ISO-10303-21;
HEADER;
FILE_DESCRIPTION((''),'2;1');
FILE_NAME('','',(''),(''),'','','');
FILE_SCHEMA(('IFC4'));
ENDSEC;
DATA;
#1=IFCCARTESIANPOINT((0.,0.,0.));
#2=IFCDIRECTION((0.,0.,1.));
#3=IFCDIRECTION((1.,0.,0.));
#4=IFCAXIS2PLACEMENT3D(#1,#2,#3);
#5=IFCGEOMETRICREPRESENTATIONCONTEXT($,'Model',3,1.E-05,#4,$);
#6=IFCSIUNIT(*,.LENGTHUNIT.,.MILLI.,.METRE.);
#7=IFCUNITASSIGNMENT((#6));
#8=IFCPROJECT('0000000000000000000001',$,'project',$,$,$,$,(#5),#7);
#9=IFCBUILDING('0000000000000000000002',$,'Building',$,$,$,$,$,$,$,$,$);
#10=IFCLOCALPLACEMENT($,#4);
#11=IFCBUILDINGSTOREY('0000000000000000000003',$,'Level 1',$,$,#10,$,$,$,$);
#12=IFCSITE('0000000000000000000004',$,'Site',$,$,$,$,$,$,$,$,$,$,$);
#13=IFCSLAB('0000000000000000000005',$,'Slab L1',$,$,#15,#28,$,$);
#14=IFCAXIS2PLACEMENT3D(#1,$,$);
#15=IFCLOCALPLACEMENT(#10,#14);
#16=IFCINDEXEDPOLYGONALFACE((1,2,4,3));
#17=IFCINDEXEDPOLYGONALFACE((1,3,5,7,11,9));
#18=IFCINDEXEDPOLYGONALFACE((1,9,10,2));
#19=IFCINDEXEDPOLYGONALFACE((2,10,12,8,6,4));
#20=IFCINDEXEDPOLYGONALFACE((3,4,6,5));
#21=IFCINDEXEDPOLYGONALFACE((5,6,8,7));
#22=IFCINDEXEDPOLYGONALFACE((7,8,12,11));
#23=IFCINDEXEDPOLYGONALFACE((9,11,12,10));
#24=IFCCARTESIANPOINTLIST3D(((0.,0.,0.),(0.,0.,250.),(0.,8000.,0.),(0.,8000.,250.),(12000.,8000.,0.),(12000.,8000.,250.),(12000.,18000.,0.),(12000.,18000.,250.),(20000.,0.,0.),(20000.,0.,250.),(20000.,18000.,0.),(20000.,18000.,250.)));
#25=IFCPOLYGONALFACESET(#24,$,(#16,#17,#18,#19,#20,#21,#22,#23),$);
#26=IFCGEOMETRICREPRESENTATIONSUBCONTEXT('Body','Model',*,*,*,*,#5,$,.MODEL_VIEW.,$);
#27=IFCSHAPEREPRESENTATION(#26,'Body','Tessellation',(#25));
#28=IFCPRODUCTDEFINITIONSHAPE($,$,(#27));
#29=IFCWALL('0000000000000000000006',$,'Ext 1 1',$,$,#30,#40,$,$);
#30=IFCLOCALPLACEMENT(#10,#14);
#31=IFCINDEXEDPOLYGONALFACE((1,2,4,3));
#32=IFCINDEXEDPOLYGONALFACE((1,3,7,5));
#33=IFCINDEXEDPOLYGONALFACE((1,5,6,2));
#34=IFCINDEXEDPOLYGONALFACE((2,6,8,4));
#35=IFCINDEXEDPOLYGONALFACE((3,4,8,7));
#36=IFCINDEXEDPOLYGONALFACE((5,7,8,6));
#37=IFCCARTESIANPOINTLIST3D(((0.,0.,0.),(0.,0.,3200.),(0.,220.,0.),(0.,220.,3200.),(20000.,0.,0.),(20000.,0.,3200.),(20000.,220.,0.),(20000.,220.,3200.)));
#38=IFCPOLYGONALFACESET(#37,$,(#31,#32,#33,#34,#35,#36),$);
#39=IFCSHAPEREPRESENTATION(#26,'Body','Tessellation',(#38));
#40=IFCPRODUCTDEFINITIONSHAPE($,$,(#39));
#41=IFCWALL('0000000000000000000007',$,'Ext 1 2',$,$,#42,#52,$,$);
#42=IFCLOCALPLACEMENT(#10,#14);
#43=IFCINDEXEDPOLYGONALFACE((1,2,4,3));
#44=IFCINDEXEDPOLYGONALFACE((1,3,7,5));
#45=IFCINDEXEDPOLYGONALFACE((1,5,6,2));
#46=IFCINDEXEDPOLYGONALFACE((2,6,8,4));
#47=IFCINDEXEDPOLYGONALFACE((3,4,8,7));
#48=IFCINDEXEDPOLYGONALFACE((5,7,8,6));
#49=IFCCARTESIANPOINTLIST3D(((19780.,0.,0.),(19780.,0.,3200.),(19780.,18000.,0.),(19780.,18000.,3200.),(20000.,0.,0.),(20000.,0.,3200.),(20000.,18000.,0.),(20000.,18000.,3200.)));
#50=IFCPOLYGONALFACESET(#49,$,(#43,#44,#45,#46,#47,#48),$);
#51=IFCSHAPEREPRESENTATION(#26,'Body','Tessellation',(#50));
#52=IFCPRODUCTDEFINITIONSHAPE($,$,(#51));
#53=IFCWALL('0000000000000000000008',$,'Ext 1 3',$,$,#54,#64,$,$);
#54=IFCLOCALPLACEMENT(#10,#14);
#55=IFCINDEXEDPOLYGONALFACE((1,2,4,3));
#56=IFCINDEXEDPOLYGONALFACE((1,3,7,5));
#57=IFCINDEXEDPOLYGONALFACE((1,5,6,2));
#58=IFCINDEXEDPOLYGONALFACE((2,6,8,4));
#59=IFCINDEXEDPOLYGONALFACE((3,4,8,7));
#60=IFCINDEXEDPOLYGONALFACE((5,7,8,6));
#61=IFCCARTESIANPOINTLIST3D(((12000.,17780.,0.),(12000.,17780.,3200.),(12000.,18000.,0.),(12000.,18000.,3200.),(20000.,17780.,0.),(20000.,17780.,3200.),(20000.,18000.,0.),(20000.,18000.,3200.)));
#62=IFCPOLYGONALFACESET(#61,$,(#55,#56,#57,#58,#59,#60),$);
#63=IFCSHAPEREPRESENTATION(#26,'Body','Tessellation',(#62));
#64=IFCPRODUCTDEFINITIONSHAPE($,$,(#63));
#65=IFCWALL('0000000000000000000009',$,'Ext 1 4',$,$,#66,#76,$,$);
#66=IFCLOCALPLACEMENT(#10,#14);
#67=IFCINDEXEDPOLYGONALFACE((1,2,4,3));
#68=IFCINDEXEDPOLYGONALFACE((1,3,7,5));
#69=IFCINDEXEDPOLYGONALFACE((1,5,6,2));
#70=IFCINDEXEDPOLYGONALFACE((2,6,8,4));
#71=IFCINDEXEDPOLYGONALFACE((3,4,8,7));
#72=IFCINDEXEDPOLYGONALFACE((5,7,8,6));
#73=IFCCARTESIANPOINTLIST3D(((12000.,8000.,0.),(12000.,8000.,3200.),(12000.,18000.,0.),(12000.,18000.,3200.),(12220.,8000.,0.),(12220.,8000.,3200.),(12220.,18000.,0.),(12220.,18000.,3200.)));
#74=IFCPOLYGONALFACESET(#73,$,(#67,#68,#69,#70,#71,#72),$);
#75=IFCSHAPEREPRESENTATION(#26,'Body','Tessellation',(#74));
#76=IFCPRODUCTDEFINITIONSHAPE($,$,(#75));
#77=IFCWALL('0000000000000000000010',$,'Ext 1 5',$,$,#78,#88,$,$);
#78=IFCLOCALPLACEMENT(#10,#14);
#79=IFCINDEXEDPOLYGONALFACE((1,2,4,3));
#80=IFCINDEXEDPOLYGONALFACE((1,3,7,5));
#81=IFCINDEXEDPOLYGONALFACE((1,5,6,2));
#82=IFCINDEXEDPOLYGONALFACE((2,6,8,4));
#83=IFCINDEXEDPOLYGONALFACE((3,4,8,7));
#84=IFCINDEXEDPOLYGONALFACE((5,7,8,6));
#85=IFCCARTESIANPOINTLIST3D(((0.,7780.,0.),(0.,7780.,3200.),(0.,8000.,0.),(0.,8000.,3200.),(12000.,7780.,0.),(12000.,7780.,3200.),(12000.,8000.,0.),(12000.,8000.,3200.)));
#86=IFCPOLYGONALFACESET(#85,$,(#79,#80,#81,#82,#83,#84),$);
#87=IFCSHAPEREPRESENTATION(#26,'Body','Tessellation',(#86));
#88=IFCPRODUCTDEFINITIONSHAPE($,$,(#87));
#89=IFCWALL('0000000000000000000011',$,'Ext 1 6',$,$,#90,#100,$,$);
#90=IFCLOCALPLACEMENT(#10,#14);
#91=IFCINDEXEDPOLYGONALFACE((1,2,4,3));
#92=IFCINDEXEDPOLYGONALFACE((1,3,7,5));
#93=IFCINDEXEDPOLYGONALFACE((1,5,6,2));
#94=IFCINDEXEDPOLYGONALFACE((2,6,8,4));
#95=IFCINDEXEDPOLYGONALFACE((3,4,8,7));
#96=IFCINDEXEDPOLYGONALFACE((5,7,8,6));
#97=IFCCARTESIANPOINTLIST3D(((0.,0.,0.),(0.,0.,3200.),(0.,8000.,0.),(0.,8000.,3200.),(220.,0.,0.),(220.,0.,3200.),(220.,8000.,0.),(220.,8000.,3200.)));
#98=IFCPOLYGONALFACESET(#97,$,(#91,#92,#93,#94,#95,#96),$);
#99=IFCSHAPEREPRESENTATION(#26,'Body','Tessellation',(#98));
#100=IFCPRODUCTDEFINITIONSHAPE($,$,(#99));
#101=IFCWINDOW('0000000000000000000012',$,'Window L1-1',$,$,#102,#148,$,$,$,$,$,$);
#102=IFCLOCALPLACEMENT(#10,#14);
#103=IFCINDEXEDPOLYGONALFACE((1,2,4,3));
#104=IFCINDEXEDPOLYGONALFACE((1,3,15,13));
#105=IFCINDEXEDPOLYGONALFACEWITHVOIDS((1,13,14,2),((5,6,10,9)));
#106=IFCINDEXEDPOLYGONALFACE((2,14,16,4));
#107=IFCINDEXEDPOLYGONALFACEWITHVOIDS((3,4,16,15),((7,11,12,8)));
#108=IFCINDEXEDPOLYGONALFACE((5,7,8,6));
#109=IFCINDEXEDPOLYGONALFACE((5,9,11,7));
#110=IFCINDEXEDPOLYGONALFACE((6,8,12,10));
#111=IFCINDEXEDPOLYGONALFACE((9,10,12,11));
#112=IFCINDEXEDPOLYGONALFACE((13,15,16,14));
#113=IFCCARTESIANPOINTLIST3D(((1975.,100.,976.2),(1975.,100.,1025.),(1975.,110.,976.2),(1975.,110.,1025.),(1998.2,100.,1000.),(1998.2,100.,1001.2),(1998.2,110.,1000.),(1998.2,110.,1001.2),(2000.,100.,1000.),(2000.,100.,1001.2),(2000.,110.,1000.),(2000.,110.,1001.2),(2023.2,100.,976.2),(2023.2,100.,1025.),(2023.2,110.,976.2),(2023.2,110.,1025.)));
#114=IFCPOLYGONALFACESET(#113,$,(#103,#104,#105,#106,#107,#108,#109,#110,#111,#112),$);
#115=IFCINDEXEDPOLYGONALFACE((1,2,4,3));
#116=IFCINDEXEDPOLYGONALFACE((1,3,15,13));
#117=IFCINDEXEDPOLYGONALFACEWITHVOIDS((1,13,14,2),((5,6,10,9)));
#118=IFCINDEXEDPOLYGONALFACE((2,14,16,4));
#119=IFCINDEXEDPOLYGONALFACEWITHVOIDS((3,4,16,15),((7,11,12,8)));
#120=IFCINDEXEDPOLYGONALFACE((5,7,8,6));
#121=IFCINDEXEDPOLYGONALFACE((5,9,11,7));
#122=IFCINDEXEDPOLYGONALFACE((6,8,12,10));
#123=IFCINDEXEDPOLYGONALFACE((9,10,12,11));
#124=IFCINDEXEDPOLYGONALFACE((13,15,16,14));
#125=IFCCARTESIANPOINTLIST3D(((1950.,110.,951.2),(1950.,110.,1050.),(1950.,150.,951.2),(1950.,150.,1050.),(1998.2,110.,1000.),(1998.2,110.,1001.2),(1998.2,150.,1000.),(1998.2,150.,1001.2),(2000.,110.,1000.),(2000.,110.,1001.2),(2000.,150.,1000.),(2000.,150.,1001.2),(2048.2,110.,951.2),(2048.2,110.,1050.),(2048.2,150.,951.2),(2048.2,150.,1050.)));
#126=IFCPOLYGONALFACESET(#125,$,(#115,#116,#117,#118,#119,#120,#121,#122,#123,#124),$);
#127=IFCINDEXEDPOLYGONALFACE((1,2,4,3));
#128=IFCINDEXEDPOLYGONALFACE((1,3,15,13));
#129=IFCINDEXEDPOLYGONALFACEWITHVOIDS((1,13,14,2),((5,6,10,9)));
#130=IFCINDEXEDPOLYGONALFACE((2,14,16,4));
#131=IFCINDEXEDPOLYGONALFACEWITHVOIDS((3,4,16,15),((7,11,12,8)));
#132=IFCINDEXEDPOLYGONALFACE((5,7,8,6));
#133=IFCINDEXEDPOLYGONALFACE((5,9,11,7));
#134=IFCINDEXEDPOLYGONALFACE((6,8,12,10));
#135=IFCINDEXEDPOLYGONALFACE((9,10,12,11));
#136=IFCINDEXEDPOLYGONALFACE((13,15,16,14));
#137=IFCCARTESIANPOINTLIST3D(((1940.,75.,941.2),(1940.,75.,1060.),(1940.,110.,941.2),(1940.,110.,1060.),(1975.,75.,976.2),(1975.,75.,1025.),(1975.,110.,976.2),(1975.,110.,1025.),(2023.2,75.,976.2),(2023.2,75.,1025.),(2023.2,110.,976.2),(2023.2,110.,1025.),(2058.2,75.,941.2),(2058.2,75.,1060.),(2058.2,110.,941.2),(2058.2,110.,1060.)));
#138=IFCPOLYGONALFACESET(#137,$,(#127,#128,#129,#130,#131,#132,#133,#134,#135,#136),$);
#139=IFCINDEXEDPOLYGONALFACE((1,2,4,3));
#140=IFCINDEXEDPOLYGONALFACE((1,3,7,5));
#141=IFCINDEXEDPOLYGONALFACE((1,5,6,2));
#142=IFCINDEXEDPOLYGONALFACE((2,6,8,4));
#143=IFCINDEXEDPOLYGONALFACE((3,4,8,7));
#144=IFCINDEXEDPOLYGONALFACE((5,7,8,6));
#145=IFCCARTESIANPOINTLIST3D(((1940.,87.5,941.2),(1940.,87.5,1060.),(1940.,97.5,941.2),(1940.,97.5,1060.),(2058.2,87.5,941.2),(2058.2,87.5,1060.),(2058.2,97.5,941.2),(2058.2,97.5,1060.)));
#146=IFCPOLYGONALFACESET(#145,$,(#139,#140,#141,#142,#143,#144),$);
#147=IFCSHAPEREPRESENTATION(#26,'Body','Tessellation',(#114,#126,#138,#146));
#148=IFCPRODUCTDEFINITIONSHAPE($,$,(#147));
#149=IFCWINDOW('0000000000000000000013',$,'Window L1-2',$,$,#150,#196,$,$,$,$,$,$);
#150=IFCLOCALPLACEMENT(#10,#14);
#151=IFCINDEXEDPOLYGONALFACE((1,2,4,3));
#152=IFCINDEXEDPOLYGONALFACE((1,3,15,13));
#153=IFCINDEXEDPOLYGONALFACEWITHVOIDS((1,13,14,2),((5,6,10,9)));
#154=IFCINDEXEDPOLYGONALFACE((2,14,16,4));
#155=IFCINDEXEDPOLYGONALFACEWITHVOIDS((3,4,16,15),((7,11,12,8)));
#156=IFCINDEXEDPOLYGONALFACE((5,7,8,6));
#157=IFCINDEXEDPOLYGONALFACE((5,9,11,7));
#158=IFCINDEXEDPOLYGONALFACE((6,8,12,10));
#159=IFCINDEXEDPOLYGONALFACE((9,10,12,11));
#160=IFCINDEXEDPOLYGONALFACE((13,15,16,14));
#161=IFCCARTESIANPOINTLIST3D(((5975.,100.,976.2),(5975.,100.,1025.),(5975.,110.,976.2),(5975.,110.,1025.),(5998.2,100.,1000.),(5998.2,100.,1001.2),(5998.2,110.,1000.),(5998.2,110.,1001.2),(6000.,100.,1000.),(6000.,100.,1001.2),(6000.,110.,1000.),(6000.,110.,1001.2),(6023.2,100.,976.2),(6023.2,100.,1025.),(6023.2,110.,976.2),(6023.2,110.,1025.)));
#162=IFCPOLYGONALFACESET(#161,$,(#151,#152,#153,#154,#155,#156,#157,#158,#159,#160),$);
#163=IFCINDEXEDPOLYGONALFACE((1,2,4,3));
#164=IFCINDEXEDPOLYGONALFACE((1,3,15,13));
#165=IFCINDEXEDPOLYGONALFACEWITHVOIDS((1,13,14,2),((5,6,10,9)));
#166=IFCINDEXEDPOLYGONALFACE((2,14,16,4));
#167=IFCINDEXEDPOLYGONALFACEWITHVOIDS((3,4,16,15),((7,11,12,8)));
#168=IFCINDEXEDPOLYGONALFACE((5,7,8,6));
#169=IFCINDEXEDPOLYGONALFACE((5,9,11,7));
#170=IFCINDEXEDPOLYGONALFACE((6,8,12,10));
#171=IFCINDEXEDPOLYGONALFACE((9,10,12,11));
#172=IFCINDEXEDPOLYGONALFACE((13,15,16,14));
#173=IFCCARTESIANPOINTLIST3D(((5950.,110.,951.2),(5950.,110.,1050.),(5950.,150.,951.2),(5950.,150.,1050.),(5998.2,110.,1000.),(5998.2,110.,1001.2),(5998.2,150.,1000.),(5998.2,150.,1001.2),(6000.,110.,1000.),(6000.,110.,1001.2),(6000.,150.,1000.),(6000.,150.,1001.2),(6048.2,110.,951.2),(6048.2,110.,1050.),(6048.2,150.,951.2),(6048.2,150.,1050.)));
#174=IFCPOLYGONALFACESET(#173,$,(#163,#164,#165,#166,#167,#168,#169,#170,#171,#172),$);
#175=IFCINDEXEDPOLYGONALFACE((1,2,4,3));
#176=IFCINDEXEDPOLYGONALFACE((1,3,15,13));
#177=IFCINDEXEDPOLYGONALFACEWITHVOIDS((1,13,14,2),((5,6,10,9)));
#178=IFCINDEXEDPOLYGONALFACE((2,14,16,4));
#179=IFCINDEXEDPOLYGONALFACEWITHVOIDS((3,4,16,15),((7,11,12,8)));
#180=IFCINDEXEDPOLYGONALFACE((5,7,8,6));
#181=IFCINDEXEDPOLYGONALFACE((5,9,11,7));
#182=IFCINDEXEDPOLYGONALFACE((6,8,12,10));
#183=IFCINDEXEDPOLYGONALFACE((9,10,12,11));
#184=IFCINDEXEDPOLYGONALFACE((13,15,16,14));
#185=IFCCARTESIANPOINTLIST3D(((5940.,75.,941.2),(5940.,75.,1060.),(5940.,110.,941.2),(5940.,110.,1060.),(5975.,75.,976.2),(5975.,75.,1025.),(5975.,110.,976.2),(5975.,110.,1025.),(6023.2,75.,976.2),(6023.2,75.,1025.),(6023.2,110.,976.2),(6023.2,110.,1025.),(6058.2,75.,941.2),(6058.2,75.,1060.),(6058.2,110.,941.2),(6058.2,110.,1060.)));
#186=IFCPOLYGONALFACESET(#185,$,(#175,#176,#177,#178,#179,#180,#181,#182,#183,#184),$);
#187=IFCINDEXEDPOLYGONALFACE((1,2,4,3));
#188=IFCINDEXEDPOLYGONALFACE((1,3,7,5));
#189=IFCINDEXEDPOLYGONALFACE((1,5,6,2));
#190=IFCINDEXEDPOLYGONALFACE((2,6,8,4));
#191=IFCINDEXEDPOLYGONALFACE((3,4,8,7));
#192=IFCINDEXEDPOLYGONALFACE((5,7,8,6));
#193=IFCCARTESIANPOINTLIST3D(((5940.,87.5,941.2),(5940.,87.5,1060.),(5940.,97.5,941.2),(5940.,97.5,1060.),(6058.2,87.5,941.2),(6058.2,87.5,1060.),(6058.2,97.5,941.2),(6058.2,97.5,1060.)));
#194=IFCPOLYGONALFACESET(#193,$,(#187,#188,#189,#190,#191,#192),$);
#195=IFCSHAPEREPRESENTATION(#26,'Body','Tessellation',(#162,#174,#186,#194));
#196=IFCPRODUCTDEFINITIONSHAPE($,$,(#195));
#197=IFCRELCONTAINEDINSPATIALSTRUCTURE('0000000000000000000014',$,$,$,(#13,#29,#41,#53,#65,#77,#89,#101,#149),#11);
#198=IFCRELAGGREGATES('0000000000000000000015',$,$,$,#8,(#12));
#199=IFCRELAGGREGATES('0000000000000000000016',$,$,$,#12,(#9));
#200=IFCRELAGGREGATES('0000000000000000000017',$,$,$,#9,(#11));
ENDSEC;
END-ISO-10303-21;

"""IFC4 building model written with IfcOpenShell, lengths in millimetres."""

from ifc_helpers import new_model, si_unit, frame, origin_with_axes, place, context, subcontext, project, spatial, line, indexed_curve, outline, extrude, element, save


model = new_model("IFC4")

# Units and contexts
model_context = context("Model", 3, precision=1e-05, world=origin_with_axes())
body_context = subcontext(model_context, "Body", "Model", "MODEL_VIEW")
ifc_project = project(units=[si_unit("LENGTHUNIT", "METRE", prefix="MILLI")], contexts=[model_context])

# Site, building, storey
site = spatial("IfcSite", under=ifc_project, Name="Site")
building = spatial("IfcBuilding", under=site, Name="Building")
storey_placement = place(None, origin_with_axes())
storey = spatial("IfcBuildingStorey", under=building, at=storey_placement, Name="Level 1")

# Slab
slab_placement = place(storey_placement, origin_with_axes())
element("IfcSlab", 1, at=slab_placement, inside=storey, Name="Slab L1", context=body_context, shape_type="SweptSolid", body=[
    extrude(outline(indexed_curve([(0.0, 0.0), (20000.0, 0.0), (20000.0, 18000.0), (12000.0, 18000.0), (12000.0, 8000.0), (0.0, 8000.0), (0.0, 0.0)])), None, (0.0, 0.0, 1.0), 250.0),
])

# Walls
wall_1_placement = place(storey_placement, origin_with_axes())
element("IfcWall", 2, at=wall_1_placement, inside=storey, Name="Ext 1 1", context=body_context, shape_type="SweptSolid", body=[
    extrude(outline(indexed_curve([(0.0, 0.0), (0.0, 220.0), (20000.0, 220.0), (20000.0, 0.0), (0.0, 0.0)], self_intersect=False)), origin_with_axes(), (0.0, 0.0, 1.0), 3200.0),
])
wall_2_placement = place(storey_placement, frame((20000.0, 0.0, 0.0), z_axis=(0.0, 0.0, 1.0), x_axis=(0.0, 1.0, 0.0)))
element("IfcWall", 3, at=wall_2_placement, inside=storey, Name="Ext 1 2", context=body_context, shape_type="SweptSolid", body=[
    extrude(outline(indexed_curve([(0.0, 0.0), (0.0, 220.0), (18000.0, 220.0), (18000.0, 0.0), (0.0, 0.0)], self_intersect=False)), origin_with_axes(), (0.0, 0.0, 1.0), 3200.0),
])
wall_3_placement = place(storey_placement, frame((20000.0, 18000.0, 0.0), z_axis=(0.0, 0.0, 1.0), x_axis=(-1.0, 0.0, 0.0)))
element("IfcWall", 4, at=wall_3_placement, inside=storey, Name="Ext 1 3", context=body_context, shape_type="SweptSolid", body=[
    extrude(outline(indexed_curve([(0.0, 0.0), (0.0, 220.0), (8000.0, 220.0), (8000.0, 0.0), (0.0, 0.0)], self_intersect=False)), origin_with_axes(), (0.0, 0.0, 1.0), 3200.0),
])
wall_4_placement = place(storey_placement, frame((12000.0, 18000.0, 0.0), z_axis=(0.0, 0.0, 1.0), x_axis=(0.0, -1.0, 0.0)))
element("IfcWall", 5, at=wall_4_placement, inside=storey, Name="Ext 1 4", context=body_context, shape_type="SweptSolid", body=[
    extrude(outline(indexed_curve([(0.0, 0.0), (0.0, 220.0), (10000.0, 220.0), (10000.0, 0.0), (0.0, 0.0)], self_intersect=False)), origin_with_axes(), (0.0, 0.0, 1.0), 3200.0),
])
wall_5_placement = place(storey_placement, frame((12000.0, 8000.0, 0.0), z_axis=(0.0, 0.0, 1.0), x_axis=(-1.0, 0.0, 0.0)))
element("IfcWall", 6, at=wall_5_placement, inside=storey, Name="Ext 1 5", context=body_context, shape_type="SweptSolid", body=[
    extrude(outline(indexed_curve([(0.0, 0.0), (0.0, 220.0), (12000.0, 220.0), (12000.0, 0.0), (0.0, 0.0)], self_intersect=False)), origin_with_axes(), (0.0, 0.0, 1.0), 3200.0),
])
wall_6_placement = place(storey_placement, frame((0.0, 8000.0, 0.0), z_axis=(0.0, 0.0, 1.0), x_axis=(0.0, -1.0, 0.0)))
element("IfcWall", 7, at=wall_6_placement, inside=storey, Name="Ext 1 6", context=body_context, shape_type="SweptSolid", body=[
    extrude(outline(indexed_curve([(0.0, 0.0), (0.0, 220.0), (8000.0, 220.0), (8000.0, 0.0), (0.0, 0.0)], self_intersect=False)), origin_with_axes(), (0.0, 0.0, 1.0), 3200.0),
])

# Windows
for number, where, z_axis, x_axis, name in (
    (8, (2000.0, 200.0, 1000.0), (0.0, 0.0, 1.0), (-1.0, 0.0, 0.0), "Window L1-1"),
    (9, (6000.0, 200.0, 1000.0), (0.0, 0.0, 1.0), (-1.0, 0.0, 0.0), "Window L1-2"),
):
    element("IfcWindow", number, at=place(storey_placement, frame(where, z_axis=z_axis, x_axis=x_axis)), inside=storey, Name=name, context=body_context, shape_type="SweptSolid", body=[
        extrude(outline(indexed_curve([(0.0, 0.0), (1.8, 0.0), (1.8, 1.2), (0.0, 1.2)], segments=[line(1, 2, 3, 4, 1)]), holes=[indexed_curve([(25.0, 25.0), (-23.2, 25.0), (-23.2, -23.8), (25.0, -23.8)], segments=[line(1, 2, 3, 4, 1)])]), frame((0.0, 90.0, 0.0), z_axis=(0.0, -1.0, 0.0), x_axis=(1.0, 0.0, 0.0)), (0.0, 0.0, -1.0), 10.0),
        extrude(outline(indexed_curve([(0.0, 0.0), (1.8, 0.0), (1.8, 1.2), (0.0, 1.2)], segments=[line(1, 2, 3, 4, 1)]), holes=[indexed_curve([(50.0, 50.0), (-48.2, 50.0), (-48.2, -48.8), (50.0, -48.8)], segments=[line(1, 2, 3, 4, 1)])]), frame((0.0, 50.0, 0.0), z_axis=(0.0, -1.0, 0.0), x_axis=(1.0, 0.0, 0.0)), (0.0, 0.0, -1.0), 40.0),
        extrude(outline(indexed_curve([(0.0, 0.0), (-48.2, 0.0), (-48.2, -48.8), (0.0, -48.8)], segments=[line(1, 2, 3, 4, 1)]), holes=[indexed_curve([(35.0, 35.0), (-83.2, 35.0), (-83.2, -83.8), (35.0, -83.8)], segments=[line(1, 2, 3, 4, 1)])]), frame((25.0, 90.0, 25.0), z_axis=(0.0, -1.0, 0.0), x_axis=(1.0, 0.0, 0.0)), (0.0, 0.0, -1.0), 35.0),
        extrude(outline(indexed_curve([(35.0, 35.0), (-83.2, 35.0), (-83.2, -83.8), (35.0, -83.8)], segments=[line(1, 2, 3, 4, 1)])), frame((25.0, 102.5, 25.0), z_axis=(0.0, -1.0, 0.0), x_axis=(1.0, 0.0, 0.0)), (0.0, 0.0, -1.0), 10.0),
    ])

save(model, "model.ifc")
